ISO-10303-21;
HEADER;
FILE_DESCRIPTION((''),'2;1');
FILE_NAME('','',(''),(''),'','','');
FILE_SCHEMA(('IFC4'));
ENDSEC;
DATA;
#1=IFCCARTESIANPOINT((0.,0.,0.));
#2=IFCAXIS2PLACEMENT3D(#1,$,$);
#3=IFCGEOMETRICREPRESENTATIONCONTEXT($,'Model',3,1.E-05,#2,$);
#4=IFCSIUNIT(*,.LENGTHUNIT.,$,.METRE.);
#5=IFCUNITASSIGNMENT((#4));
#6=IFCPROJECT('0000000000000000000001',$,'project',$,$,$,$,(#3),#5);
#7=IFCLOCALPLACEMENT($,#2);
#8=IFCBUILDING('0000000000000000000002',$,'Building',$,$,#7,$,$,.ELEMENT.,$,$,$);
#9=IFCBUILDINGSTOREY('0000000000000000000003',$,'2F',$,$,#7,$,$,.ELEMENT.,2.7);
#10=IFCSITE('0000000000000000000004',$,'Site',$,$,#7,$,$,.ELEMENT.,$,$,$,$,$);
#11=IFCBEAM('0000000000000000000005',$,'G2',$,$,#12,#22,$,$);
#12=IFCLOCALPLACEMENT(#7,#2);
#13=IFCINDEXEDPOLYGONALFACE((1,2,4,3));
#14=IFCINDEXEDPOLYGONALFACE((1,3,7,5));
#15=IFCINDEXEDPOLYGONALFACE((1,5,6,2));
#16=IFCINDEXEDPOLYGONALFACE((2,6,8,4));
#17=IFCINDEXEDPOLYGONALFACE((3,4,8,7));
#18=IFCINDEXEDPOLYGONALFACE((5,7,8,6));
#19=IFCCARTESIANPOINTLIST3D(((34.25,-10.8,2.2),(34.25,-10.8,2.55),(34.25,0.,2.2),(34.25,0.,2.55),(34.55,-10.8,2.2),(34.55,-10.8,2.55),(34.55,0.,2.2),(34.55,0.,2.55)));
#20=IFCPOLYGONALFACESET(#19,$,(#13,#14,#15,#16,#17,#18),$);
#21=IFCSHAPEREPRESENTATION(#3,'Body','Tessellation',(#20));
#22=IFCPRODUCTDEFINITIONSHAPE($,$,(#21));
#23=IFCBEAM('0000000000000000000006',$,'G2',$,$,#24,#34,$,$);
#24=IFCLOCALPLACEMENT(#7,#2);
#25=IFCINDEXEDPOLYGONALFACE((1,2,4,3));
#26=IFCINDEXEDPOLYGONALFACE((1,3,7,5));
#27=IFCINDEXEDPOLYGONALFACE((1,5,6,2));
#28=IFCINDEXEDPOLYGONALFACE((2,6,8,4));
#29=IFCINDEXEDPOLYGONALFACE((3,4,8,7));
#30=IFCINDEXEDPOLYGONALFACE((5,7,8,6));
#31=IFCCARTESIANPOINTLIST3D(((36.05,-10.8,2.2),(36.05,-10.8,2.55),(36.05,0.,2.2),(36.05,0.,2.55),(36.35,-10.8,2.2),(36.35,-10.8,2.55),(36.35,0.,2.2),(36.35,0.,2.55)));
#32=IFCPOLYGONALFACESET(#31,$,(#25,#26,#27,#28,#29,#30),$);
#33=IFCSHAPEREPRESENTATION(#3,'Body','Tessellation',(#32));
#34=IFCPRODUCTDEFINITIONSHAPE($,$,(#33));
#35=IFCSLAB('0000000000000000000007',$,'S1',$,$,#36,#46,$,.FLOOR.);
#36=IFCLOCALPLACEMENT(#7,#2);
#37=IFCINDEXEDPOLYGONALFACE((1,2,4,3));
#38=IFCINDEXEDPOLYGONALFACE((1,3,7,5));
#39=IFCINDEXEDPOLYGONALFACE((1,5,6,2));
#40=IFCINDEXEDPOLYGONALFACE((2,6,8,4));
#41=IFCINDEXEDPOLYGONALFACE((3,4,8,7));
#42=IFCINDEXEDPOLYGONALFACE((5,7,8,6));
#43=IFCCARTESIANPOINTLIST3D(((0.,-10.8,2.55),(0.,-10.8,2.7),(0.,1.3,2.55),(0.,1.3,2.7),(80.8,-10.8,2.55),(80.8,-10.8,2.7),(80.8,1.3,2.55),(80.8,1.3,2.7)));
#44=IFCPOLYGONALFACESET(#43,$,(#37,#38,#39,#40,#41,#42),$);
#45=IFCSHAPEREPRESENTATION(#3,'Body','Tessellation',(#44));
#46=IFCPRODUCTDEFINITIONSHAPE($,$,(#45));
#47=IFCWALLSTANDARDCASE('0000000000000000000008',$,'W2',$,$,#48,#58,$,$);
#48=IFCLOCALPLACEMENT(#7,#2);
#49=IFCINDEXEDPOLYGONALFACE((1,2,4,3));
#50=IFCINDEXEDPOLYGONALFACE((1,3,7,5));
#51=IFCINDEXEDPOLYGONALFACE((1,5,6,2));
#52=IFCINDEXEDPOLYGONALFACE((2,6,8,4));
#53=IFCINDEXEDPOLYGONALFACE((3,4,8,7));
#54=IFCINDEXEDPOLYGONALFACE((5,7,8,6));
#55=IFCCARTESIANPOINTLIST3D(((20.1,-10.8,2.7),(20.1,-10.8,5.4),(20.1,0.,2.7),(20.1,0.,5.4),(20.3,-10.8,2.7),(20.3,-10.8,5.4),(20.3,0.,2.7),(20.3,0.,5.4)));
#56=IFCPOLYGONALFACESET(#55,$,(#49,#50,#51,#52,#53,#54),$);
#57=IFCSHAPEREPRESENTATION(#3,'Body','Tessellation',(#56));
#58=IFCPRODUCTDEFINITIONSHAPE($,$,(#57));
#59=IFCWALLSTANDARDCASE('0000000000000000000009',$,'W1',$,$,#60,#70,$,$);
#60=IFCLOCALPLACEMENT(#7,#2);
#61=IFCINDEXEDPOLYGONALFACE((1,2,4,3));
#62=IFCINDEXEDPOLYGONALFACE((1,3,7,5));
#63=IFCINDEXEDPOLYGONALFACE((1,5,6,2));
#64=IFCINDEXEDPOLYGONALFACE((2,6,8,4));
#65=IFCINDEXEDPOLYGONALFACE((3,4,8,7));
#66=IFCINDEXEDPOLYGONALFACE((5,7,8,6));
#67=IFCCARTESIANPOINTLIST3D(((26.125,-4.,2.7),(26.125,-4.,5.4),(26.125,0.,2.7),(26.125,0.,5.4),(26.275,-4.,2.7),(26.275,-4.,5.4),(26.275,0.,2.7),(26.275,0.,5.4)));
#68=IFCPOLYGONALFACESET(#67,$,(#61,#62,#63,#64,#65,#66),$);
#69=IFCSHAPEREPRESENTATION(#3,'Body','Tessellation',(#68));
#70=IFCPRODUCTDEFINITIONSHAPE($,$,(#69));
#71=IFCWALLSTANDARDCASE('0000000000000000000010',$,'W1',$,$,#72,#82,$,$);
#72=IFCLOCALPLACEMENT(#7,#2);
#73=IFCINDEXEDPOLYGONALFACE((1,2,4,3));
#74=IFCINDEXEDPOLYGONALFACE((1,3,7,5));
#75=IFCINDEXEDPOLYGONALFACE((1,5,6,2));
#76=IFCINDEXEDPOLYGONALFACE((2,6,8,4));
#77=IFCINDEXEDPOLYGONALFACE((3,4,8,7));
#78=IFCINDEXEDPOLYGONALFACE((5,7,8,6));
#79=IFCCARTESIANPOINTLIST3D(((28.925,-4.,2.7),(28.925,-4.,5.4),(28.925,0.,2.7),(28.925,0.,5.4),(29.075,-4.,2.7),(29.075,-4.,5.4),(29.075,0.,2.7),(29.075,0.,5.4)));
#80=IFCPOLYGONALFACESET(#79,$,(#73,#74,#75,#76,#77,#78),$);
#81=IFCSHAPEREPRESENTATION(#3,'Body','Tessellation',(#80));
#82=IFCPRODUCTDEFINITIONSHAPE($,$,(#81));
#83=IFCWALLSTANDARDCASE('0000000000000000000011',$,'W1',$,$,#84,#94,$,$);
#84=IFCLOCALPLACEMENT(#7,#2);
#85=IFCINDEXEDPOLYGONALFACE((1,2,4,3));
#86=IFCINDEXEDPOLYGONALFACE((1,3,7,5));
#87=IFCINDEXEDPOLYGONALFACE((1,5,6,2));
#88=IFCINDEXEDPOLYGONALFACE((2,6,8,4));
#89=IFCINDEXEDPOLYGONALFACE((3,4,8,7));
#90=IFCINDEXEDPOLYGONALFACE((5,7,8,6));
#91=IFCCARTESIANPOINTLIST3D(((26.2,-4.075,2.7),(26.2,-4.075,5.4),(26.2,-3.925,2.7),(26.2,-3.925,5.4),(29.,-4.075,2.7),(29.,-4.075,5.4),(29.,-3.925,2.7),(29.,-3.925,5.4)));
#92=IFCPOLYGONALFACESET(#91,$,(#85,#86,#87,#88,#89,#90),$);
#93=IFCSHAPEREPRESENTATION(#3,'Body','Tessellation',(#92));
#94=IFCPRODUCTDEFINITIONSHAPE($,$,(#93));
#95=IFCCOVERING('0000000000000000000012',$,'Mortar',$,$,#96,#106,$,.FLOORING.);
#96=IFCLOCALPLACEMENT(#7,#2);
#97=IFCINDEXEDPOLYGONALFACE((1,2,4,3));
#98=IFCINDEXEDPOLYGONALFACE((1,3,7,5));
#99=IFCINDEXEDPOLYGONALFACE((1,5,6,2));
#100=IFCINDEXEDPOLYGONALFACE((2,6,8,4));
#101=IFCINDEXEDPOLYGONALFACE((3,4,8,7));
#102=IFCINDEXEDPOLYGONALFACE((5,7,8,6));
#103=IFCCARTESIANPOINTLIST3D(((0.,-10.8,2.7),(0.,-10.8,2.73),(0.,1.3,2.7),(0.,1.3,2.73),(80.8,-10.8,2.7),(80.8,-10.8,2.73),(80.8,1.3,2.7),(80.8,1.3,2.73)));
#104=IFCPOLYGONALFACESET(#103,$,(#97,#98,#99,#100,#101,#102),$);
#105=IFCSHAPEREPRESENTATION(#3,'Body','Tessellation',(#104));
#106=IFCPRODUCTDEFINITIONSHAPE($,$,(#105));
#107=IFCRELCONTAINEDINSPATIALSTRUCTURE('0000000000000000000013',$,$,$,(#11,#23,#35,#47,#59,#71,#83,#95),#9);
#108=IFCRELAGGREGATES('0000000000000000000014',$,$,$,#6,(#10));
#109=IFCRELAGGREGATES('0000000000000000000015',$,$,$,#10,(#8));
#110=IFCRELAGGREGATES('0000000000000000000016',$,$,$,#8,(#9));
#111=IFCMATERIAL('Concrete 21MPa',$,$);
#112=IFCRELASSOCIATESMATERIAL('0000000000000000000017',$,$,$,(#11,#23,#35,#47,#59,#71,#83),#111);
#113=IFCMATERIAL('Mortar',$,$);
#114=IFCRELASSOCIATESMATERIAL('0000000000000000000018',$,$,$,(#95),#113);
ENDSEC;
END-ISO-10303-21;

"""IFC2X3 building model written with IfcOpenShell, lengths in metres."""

from ifc_helpers import new_model, si_unit, frame, origin, origin_2d, place, context, project, spatial, rectangle, extrude, material, element, save


model = new_model("IFC2X3")

# Units and contexts
model_context = context("Model", 3, precision=1e-05, world=origin())
ifc_project = project(units=[si_unit("LENGTHUNIT", "METRE")], contexts=[model_context])

# Site, building, storey
placement = place(None, origin())
site = spatial("IfcSite", under=ifc_project, at=placement, Name="Site", CompositionType="ELEMENT")
building = spatial("IfcBuilding", under=site, at=placement, Name="Building", CompositionType="ELEMENT")
storey = spatial("IfcBuildingStorey", under=building, at=placement, Name="2F", CompositionType="ELEMENT", Elevation=2.7)

# Shared definitions
ifc_material_1 = material(Name="Concrete 21MPa")

# Beams
for number, where, name in (
    (1, (34.4, -5.4, 2.2), "G2"),
    (2, (36.2, -5.4, 2.2), "G2"),
):
    element("IfcBeam", number, at=place(None, frame(where)), inside=storey, material=ifc_material_1, Name=name, context=model_context, shape_type="SweptSolid", body=[
        extrude(rectangle(XDim=0.3, YDim=10.8, at=origin_2d()), origin(), (0.0, 0.0, 1.0), 0.35),
    ])

# Slab
slab_placement = place(None, frame((40.4, -4.75, 2.55)))
element("IfcSlab", 3, at=slab_placement, inside=storey, material=ifc_material_1, Name="S1", PredefinedType="FLOOR", context=model_context, shape_type="SweptSolid", body=[
    extrude(rectangle(XDim=80.8, YDim=12.1, at=origin_2d()), origin(), (0.0, 0.0, 1.0), 0.15),
])

# Walls
wall_1_placement = place(None, frame((20.2, -5.4, 2.7)))
element("IfcWallStandardCase", 4, at=wall_1_placement, inside=storey, material=ifc_material_1, Name="W2", context=model_context, shape_type="SweptSolid", body=[
    extrude(rectangle(XDim=0.2, YDim=10.8, at=origin_2d()), origin(), (0.0, 0.0, 1.0), 2.7),
])
for number, where, name in (
    (5, (26.2, -2.0, 2.7), "W1"),
    (6, (29.0, -2.0, 2.7), "W1"),
):
    element("IfcWallStandardCase", number, at=place(None, frame(where)), inside=storey, material=ifc_material_1, Name=name, context=model_context, shape_type="SweptSolid", body=[
        extrude(rectangle(XDim=0.15, YDim=4.0, at=origin_2d()), origin(), (0.0, 0.0, 1.0), 2.7),
    ])
wall_2_placement = place(None, frame((27.6, -4.0, 2.7)))
element("IfcWallStandardCase", 7, at=wall_2_placement, inside=storey, material=ifc_material_1, Name="W1", context=model_context, shape_type="SweptSolid", body=[
    extrude(rectangle(XDim=2.8, YDim=0.15, at=origin_2d()), origin(), (0.0, 0.0, 1.0), 2.7),
])

# Covering
ifc_material_2 = material(Name="Mortar")
covering_placement = place(None, frame((40.4, -4.75, 2.7)))
element("IfcCovering", 8, at=covering_placement, inside=storey, material=ifc_material_2, Name="Mortar", PredefinedType="FLOORING", context=model_context, shape_type="SweptSolid", body=[
    extrude(rectangle(XDim=80.8, YDim=12.1, at=origin_2d()), origin(), (0.0, 0.0, 1.0), 0.03),
])

save(model, "model.ifc")
